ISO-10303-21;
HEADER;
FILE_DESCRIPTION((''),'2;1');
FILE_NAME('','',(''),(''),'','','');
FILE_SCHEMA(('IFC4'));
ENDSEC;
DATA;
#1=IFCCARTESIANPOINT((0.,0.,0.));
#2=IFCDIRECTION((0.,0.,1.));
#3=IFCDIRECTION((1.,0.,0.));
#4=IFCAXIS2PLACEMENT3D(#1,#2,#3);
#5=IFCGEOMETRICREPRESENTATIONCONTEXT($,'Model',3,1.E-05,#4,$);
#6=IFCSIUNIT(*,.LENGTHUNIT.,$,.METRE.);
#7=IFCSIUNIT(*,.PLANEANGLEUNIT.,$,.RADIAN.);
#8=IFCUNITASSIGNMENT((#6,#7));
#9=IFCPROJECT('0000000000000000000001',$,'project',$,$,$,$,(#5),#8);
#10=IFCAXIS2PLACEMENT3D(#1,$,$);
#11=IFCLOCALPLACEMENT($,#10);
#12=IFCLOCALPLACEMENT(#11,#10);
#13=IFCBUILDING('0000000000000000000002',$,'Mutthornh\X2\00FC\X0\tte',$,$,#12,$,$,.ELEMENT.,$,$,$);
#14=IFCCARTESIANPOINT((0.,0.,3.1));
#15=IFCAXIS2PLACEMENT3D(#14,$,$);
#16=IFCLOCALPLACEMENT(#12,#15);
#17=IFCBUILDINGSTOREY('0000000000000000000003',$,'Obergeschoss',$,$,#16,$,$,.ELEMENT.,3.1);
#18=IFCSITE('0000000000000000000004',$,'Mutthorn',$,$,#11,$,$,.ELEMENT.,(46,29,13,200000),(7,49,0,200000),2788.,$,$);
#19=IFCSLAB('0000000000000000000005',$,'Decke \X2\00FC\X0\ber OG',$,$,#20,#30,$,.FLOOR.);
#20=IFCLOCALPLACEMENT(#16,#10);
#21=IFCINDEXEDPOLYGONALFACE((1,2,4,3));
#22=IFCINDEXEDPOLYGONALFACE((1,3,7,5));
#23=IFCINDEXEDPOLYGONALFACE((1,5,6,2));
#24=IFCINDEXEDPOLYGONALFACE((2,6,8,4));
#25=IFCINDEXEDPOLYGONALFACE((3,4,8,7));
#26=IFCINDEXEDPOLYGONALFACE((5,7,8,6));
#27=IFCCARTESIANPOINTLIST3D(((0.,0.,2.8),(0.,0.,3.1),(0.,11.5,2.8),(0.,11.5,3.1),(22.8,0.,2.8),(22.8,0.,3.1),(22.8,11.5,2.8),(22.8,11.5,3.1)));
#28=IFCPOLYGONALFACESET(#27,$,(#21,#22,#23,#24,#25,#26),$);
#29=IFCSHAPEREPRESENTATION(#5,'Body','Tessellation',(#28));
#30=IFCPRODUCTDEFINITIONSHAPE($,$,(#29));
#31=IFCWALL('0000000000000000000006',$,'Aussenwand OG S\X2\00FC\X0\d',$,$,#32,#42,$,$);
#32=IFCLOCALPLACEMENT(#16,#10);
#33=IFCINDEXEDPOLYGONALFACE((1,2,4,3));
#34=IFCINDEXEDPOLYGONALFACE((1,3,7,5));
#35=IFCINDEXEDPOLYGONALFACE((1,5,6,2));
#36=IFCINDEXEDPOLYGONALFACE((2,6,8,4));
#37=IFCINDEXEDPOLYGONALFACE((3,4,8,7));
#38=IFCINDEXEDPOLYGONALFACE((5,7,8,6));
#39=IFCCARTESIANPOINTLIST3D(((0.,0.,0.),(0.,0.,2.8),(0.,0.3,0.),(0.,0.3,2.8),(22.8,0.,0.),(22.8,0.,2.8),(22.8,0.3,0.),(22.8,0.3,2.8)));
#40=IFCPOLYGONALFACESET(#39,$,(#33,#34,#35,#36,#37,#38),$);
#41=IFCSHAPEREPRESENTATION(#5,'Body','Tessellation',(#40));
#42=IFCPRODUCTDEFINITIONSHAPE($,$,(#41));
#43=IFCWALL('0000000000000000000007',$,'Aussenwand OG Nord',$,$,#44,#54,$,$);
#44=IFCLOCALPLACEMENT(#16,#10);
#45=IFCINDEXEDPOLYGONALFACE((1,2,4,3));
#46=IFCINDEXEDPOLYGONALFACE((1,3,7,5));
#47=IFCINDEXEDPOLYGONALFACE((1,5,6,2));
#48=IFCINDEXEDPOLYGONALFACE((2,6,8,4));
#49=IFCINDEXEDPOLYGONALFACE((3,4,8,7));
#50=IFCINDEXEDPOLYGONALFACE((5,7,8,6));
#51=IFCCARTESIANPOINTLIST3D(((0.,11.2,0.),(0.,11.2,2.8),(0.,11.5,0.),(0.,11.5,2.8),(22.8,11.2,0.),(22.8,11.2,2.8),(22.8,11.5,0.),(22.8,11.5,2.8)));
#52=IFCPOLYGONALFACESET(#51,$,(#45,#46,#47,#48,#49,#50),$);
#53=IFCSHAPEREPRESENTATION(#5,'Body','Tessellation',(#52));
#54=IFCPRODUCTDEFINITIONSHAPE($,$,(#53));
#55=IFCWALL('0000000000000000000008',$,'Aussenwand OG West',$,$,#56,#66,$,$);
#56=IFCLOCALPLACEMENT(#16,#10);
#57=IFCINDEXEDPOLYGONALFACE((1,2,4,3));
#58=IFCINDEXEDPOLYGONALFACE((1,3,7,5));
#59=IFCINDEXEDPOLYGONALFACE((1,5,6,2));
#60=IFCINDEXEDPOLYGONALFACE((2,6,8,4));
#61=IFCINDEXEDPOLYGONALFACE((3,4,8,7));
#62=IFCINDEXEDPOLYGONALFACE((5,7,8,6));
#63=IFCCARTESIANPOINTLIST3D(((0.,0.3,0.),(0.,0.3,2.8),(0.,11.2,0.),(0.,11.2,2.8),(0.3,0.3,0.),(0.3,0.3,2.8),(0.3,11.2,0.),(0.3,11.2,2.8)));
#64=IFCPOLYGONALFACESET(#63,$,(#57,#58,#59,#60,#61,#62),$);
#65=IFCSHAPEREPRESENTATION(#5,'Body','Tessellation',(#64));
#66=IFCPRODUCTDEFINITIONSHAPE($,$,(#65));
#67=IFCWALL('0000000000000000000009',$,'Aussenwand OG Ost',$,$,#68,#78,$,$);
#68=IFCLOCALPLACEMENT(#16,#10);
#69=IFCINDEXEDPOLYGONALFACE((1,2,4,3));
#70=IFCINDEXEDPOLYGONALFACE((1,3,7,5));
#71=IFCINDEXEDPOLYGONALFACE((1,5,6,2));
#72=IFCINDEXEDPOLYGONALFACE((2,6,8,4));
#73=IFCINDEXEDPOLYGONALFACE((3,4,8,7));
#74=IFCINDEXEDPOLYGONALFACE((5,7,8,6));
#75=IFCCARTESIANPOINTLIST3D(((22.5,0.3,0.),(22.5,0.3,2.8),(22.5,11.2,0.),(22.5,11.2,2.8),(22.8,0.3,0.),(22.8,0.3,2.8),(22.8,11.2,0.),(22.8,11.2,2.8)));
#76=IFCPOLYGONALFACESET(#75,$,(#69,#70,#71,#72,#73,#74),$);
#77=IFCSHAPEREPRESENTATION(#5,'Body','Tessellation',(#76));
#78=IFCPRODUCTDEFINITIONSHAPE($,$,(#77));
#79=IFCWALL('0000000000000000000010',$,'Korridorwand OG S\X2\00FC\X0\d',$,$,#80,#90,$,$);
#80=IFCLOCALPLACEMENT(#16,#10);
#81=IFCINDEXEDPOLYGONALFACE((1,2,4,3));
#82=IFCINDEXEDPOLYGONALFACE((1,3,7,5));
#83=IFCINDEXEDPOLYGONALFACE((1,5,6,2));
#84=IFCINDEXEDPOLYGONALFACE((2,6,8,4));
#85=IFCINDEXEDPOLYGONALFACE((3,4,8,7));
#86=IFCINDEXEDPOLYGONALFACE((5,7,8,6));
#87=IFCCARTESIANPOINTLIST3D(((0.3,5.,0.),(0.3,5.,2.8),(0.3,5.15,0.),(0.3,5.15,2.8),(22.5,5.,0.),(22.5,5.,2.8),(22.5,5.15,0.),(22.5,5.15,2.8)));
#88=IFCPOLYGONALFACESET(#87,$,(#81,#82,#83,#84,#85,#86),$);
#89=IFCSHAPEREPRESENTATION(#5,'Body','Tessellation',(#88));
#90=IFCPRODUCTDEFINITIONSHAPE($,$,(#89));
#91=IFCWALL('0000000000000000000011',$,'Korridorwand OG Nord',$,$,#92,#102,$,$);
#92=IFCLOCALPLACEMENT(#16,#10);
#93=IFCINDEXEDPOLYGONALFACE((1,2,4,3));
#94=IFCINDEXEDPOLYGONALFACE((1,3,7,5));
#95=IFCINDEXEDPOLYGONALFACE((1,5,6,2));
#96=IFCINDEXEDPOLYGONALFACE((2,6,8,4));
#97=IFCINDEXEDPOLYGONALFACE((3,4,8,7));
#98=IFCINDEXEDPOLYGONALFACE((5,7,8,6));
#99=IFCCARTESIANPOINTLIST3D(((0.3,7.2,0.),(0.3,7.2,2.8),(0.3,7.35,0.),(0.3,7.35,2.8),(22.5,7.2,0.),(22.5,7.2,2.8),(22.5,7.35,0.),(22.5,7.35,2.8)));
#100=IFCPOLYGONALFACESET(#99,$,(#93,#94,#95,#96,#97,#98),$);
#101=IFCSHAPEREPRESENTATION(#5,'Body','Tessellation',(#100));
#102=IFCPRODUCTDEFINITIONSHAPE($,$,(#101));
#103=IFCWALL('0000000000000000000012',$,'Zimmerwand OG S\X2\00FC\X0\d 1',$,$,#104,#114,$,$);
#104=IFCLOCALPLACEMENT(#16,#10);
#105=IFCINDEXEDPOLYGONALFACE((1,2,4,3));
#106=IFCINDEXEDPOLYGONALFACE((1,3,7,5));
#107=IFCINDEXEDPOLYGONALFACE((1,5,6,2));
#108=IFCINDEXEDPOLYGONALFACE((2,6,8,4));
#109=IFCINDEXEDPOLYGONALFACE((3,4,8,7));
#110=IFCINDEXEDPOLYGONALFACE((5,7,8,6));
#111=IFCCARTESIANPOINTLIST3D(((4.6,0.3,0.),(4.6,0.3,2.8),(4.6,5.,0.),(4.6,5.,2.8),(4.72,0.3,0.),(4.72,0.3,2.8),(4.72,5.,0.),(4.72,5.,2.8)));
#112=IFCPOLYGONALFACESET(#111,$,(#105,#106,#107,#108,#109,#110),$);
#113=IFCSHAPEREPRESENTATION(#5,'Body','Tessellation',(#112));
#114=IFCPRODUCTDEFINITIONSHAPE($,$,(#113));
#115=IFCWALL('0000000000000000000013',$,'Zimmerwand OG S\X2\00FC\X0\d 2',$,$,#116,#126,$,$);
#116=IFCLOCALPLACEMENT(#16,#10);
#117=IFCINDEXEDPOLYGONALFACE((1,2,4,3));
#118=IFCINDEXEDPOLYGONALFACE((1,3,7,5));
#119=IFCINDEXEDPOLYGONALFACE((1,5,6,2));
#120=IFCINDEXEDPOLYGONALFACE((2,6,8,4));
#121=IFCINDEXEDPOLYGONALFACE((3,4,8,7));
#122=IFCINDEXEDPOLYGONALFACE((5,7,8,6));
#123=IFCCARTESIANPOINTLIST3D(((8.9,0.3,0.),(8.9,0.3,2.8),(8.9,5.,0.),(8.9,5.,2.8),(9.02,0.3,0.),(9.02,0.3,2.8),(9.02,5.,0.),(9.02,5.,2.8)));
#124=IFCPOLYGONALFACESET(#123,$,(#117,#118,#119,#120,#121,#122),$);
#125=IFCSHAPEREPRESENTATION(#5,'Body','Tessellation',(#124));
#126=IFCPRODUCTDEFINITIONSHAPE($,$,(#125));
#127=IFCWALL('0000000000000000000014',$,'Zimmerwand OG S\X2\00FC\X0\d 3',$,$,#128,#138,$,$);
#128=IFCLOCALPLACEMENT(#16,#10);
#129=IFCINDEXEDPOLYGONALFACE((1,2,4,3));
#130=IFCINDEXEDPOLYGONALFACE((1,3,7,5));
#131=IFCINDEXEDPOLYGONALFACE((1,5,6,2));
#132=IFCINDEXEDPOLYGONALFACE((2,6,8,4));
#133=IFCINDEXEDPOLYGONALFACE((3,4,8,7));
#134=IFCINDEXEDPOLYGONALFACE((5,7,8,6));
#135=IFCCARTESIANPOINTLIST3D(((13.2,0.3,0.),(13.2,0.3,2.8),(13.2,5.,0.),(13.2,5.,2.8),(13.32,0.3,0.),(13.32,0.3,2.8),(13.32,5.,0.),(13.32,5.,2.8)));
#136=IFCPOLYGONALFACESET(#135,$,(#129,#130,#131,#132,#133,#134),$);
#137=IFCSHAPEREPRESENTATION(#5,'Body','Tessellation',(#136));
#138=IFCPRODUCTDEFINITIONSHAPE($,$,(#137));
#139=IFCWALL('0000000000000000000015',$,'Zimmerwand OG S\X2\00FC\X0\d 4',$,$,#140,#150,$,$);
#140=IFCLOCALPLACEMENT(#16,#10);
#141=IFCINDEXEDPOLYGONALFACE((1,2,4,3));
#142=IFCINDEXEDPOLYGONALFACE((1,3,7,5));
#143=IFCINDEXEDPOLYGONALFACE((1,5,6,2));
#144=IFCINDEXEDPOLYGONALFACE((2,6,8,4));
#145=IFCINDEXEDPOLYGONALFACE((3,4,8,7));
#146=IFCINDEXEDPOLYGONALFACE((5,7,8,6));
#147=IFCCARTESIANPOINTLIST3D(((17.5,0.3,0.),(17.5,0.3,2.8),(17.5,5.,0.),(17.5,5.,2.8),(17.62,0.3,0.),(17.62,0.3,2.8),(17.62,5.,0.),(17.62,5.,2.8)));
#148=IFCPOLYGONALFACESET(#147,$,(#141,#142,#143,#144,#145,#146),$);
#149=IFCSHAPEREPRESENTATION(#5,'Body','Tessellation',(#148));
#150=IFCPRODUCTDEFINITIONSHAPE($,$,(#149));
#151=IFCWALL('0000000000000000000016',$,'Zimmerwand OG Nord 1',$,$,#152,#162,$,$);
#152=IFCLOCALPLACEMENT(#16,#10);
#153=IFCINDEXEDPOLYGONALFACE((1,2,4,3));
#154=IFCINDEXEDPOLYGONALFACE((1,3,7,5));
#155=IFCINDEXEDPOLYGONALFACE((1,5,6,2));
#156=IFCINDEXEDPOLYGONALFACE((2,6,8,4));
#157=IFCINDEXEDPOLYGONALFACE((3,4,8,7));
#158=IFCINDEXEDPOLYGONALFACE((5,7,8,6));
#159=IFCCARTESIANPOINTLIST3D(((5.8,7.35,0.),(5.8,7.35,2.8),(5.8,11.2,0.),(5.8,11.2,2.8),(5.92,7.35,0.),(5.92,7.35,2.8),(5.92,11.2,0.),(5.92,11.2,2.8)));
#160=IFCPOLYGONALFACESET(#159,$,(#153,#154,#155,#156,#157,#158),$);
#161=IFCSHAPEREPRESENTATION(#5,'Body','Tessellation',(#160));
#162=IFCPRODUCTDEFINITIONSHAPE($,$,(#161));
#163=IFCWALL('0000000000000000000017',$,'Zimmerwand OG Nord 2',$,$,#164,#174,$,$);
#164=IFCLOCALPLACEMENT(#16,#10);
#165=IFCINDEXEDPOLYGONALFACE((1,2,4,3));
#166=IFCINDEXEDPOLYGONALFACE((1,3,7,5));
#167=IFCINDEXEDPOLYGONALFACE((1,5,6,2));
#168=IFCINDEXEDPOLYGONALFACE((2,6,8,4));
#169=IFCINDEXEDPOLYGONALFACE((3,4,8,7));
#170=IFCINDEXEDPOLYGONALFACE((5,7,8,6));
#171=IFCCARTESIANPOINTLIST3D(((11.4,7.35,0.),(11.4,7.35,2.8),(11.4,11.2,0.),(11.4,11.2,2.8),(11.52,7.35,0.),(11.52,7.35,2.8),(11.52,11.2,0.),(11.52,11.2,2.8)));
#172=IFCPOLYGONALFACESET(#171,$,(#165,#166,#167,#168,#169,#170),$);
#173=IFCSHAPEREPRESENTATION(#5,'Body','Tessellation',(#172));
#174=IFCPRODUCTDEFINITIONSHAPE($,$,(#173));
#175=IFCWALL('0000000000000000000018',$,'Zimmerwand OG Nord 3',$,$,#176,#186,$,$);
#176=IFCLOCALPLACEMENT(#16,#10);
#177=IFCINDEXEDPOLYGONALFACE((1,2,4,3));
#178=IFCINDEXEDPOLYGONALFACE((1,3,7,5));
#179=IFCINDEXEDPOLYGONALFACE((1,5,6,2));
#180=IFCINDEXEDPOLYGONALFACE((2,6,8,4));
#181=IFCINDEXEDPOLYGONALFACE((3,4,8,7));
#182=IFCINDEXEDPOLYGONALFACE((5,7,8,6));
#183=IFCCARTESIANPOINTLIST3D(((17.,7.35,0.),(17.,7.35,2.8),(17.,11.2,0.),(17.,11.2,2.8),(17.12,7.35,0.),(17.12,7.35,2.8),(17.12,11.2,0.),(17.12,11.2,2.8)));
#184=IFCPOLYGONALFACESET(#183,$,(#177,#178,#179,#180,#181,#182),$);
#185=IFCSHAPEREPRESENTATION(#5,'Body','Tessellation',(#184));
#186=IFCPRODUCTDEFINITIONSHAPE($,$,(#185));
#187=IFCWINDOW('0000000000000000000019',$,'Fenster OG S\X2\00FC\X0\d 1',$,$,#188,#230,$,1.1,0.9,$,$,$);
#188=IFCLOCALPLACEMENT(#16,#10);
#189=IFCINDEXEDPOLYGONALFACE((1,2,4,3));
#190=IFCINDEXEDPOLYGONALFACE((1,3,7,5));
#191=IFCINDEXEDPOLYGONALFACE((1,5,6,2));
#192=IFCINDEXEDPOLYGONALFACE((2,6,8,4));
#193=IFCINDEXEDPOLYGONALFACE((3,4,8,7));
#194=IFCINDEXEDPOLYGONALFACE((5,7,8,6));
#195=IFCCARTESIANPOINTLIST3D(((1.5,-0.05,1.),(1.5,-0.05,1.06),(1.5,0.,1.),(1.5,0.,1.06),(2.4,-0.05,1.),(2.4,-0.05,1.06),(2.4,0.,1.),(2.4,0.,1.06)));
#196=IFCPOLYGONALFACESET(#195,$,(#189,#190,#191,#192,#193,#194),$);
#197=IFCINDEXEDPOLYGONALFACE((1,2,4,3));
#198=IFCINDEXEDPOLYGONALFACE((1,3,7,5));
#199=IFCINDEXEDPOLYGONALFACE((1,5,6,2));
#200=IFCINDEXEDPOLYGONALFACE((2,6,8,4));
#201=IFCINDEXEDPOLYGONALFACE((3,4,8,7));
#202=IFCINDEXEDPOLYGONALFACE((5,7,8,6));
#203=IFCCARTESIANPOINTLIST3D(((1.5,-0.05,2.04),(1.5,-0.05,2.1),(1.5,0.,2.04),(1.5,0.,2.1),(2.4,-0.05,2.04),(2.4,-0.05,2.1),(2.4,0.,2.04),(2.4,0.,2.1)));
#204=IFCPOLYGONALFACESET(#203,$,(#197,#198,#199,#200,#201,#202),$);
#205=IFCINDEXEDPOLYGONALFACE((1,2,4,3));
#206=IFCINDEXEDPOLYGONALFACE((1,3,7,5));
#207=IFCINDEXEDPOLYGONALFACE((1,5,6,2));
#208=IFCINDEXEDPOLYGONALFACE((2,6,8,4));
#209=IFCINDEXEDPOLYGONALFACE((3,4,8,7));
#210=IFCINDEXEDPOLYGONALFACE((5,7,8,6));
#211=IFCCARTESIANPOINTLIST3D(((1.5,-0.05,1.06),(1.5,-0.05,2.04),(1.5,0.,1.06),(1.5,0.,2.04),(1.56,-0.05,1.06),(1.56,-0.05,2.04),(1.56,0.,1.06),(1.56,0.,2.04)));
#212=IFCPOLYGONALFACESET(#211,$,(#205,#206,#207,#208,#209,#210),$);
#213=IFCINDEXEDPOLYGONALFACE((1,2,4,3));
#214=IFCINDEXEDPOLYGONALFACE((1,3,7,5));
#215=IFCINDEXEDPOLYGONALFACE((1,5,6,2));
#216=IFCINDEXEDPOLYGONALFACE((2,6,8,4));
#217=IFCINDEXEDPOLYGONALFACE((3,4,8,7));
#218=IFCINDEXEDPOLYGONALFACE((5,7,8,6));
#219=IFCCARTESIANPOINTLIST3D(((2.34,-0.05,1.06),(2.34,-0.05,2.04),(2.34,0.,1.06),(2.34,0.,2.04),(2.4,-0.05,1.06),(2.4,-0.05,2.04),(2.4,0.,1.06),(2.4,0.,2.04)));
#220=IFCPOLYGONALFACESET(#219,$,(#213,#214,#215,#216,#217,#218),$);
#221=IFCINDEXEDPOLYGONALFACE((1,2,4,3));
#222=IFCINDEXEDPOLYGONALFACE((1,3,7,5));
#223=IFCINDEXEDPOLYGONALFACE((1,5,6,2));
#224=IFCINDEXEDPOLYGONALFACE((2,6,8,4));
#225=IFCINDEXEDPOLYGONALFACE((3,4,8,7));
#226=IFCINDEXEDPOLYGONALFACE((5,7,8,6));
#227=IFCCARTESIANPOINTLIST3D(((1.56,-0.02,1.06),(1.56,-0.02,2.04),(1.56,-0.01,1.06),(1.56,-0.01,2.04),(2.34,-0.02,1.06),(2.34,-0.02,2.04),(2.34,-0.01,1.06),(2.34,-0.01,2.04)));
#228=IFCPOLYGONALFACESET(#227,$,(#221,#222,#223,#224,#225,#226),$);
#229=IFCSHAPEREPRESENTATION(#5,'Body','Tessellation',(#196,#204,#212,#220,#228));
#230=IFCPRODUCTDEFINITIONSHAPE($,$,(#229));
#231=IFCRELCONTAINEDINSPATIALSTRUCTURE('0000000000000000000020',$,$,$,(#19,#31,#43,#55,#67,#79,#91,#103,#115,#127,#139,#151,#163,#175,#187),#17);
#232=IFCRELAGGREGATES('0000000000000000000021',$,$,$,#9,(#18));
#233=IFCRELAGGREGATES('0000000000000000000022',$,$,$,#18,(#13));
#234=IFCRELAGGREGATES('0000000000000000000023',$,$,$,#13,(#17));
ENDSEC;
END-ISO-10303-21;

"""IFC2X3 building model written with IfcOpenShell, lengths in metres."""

from ifc_helpers import new_model, si_unit, frame, frame_2d, origin, origin_with_axes, place, context, project, spatial, rectangle, extrude, element, save


model = new_model("IFC2X3")

# Units and contexts
model_context = context("Model", 3, precision=1e-05, world=origin_with_axes())
ifc_project = project(units=[si_unit("LENGTHUNIT", "METRE"), si_unit("PLANEANGLEUNIT", "RADIAN")], contexts=[model_context])

# Site, building, storey
site_placement = place(None, origin())
site = spatial("IfcSite", under=ifc_project, at=site_placement, Name="Mutthorn", CompositionType="ELEMENT", RefLatitude=(46, 29, 13, 200000), RefLongitude=(7, 49, 0, 200000), RefElevation=2788.0)
building_placement = place(site_placement, origin())
building = spatial("IfcBuilding", under=site, at=building_placement, Name="Mutthornhütte", CompositionType="ELEMENT")
storey_placement = place(building_placement, frame((0.0, 0.0, 3.1)))
storey = spatial("IfcBuildingStorey", under=building, at=storey_placement, Name="Obergeschoss", CompositionType="ELEMENT", Elevation=3.1)

# Slab
slab_placement = place(storey_placement, origin())
element("IfcSlab", 1, at=slab_placement, inside=storey, Name="Decke über OG", PredefinedType="FLOOR", context=model_context, shape_type="SweptSolid", body=[
    extrude(rectangle(XDim=22.8, YDim=11.5, at=frame_2d((11.4, 5.75))), frame((0.0, 0.0, 2.8)), (0.0, 0.0, 1.0), 0.3),
])

# Walls
wall_1_placement = place(storey_placement, origin())
element("IfcWall", 2, at=wall_1_placement, inside=storey, Name="Aussenwand OG Süd", context=model_context, shape_type="SweptSolid", body=[
    extrude(rectangle(XDim=22.8, YDim=0.3, at=frame_2d((11.4, 0.15))), origin(), (0.0, 0.0, 1.0), 2.8),
])
wall_2_placement = place(storey_placement, origin())
element("IfcWall", 3, at=wall_2_placement, inside=storey, Name="Aussenwand OG Nord", context=model_context, shape_type="SweptSolid", body=[
    extrude(rectangle(XDim=22.8, YDim=0.3, at=frame_2d((11.4, 0.15))), frame((0.0, 11.2, 0.0)), (0.0, 0.0, 1.0), 2.8),
])
wall_3_placement = place(storey_placement, origin())
element("IfcWall", 4, at=wall_3_placement, inside=storey, Name="Aussenwand OG West", context=model_context, shape_type="SweptSolid", body=[
    extrude(rectangle(XDim=0.3, YDim=10.9, at=frame_2d((0.15, 5.45))), frame((0.0, 0.3, 0.0)), (0.0, 0.0, 1.0), 2.8),
])
wall_4_placement = place(storey_placement, origin())
element("IfcWall", 5, at=wall_4_placement, inside=storey, Name="Aussenwand OG Ost", context=model_context, shape_type="SweptSolid", body=[
    extrude(rectangle(XDim=0.3, YDim=10.9, at=frame_2d((0.15, 5.45))), frame((22.5, 0.3, 0.0)), (0.0, 0.0, 1.0), 2.8),
])
wall_5_placement = place(storey_placement, origin())
element("IfcWall", 6, at=wall_5_placement, inside=storey, Name="Korridorwand OG Süd", context=model_context, shape_type="SweptSolid", body=[
    extrude(rectangle(XDim=22.2, YDim=0.15, at=frame_2d((11.1, 0.075))), frame((0.3, 5.0, 0.0)), (0.0, 0.0, 1.0), 2.8),
])
wall_6_placement = place(storey_placement, origin())
element("IfcWall", 7, at=wall_6_placement, inside=storey, Name="Korridorwand OG Nord", context=model_context, shape_type="SweptSolid", body=[
    extrude(rectangle(XDim=22.2, YDim=0.15, at=frame_2d((11.1, 0.075))), frame((0.3, 7.2, 0.0)), (0.0, 0.0, 1.0), 2.8),
])
wall_7_placement = place(storey_placement, origin())
element("IfcWall", 8, at=wall_7_placement, inside=storey, Name="Zimmerwand OG Süd 1", context=model_context, shape_type="SweptSolid", body=[
    extrude(rectangle(XDim=0.12, YDim=4.7, at=frame_2d((0.06, 2.35))), frame((4.6, 0.3, 0.0)), (0.0, 0.0, 1.0), 2.8),
])
wall_8_placement = place(storey_placement, origin())
element("IfcWall", 9, at=wall_8_placement, inside=storey, Name="Zimmerwand OG Süd 2", context=model_context, shape_type="SweptSolid", body=[
    extrude(rectangle(XDim=0.12, YDim=4.7, at=frame_2d((0.06, 2.35))), frame((8.9, 0.3, 0.0)), (0.0, 0.0, 1.0), 2.8),
])
wall_9_placement = place(storey_placement, origin())
element("IfcWall", 10, at=wall_9_placement, inside=storey, Name="Zimmerwand OG Süd 3", context=model_context, shape_type="SweptSolid", body=[
    extrude(rectangle(XDim=0.12, YDim=4.7, at=frame_2d((0.06, 2.35))), frame((13.2, 0.3, 0.0)), (0.0, 0.0, 1.0), 2.8),
])
wall_10_placement = place(storey_placement, origin())
element("IfcWall", 11, at=wall_10_placement, inside=storey, Name="Zimmerwand OG Süd 4", context=model_context, shape_type="SweptSolid", body=[
    extrude(rectangle(XDim=0.12, YDim=4.7, at=frame_2d((0.06, 2.35))), frame((17.5, 0.3, 0.0)), (0.0, 0.0, 1.0), 2.8),
])
wall_11_placement = place(storey_placement, origin())
element("IfcWall", 12, at=wall_11_placement, inside=storey, Name="Zimmerwand OG Nord 1", context=model_context, shape_type="SweptSolid", body=[
    extrude(rectangle(XDim=0.12, YDim=3.85, at=frame_2d((0.06, 1.925))), frame((5.8, 7.35, 0.0)), (0.0, 0.0, 1.0), 2.8),
])
wall_12_placement = place(storey_placement, origin())
element("IfcWall", 13, at=wall_12_placement, inside=storey, Name="Zimmerwand OG Nord 2", context=model_context, shape_type="SweptSolid", body=[
    extrude(rectangle(XDim=0.12, YDim=3.85, at=frame_2d((0.06, 1.925))), frame((11.4, 7.35, 0.0)), (0.0, 0.0, 1.0), 2.8),
])
wall_13_placement = place(storey_placement, origin())
element("IfcWall", 14, at=wall_13_placement, inside=storey, Name="Zimmerwand OG Nord 3", context=model_context, shape_type="SweptSolid", body=[
    extrude(rectangle(XDim=0.12, YDim=3.85, at=frame_2d((0.06, 1.925))), frame((17.0, 7.35, 0.0)), (0.0, 0.0, 1.0), 2.8),
])

# Window
window_1_placement = place(storey_placement, origin())
element("IfcWindow", 15, at=window_1_placement, inside=storey, Name="Fenster OG Süd 1", OverallHeight=1.1, OverallWidth=0.9, context=model_context, shape_type="SweptSolid", body=[
    extrude(rectangle(XDim=0.9, YDim=0.05, at=frame_2d((0.45, 0.025))), frame((1.5, -0.05, 1.0)), (0.0, 0.0, 1.0), 0.06),
    extrude(rectangle(XDim=0.9, YDim=0.05, at=frame_2d((0.45, 0.025))), frame((1.5, -0.05, 2.04)), (0.0, 0.0, 1.0), 0.06),
    extrude(rectangle(XDim=0.06, YDim=0.05, at=frame_2d((0.03, 0.025))), frame((1.5, -0.05, 1.06)), (0.0, 0.0, 1.0), 0.98),
    extrude(rectangle(XDim=0.06, YDim=0.05, at=frame_2d((0.03, 0.025))), frame((2.34, -0.05, 1.06)), (0.0, 0.0, 1.0), 0.98),
    extrude(rectangle(XDim=0.78, YDim=0.01, at=frame_2d((0.39, 0.005))), frame((1.56, -0.02, 1.06)), (0.0, 0.0, 1.0), 0.98),
])

save(model, "model.ifc")
